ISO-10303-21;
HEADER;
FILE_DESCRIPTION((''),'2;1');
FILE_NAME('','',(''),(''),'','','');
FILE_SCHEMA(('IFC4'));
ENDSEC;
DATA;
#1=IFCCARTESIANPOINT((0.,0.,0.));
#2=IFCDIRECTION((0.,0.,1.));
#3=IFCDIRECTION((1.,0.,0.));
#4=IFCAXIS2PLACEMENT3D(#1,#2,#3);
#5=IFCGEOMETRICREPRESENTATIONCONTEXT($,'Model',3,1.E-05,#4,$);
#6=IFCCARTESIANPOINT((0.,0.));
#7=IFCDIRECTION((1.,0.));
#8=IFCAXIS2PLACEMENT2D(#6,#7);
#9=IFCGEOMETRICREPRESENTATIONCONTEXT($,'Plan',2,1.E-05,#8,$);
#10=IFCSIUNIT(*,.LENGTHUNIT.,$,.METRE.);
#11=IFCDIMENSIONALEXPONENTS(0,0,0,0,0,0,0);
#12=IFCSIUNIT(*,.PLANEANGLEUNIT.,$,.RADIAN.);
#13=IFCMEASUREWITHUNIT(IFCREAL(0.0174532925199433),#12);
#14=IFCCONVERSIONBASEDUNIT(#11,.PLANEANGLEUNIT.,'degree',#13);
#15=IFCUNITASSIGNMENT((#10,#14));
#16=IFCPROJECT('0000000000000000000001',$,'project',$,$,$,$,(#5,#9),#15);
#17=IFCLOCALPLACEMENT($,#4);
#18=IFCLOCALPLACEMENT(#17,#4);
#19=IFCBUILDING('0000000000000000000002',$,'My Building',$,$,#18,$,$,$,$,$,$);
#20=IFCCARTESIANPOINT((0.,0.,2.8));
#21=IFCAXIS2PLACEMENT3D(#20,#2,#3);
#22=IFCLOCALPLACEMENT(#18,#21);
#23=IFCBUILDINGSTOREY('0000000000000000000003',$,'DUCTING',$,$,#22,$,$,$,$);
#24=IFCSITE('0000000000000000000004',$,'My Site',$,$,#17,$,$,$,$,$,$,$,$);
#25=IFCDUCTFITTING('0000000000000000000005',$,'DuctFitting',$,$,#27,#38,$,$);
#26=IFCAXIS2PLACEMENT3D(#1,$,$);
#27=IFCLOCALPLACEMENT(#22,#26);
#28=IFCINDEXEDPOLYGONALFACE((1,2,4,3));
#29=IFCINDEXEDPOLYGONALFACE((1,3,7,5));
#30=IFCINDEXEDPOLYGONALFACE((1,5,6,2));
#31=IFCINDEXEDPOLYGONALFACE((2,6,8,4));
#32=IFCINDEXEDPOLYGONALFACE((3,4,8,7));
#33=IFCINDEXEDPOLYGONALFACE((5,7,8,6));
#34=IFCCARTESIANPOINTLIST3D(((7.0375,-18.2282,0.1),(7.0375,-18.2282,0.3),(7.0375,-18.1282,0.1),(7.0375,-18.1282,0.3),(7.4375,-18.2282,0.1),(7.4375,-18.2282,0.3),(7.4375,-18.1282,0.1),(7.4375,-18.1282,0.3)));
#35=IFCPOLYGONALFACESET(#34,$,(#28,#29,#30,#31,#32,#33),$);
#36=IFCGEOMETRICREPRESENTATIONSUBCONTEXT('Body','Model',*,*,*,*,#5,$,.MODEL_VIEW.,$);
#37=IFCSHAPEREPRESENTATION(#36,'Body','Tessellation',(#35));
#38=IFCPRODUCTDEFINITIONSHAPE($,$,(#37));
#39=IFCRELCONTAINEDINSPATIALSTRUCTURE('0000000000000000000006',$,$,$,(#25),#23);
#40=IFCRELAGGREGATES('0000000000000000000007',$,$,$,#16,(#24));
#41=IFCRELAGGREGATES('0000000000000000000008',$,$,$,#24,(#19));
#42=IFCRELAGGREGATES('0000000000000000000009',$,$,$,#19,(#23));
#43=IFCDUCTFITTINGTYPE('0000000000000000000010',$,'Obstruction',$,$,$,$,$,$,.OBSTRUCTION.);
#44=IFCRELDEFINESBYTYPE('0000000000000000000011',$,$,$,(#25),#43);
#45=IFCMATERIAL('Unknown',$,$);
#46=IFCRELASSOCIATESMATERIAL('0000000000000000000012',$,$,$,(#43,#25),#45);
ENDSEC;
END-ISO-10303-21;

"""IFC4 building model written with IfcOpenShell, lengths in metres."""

from ifc_helpers import new_model, entity, si_unit, converted_unit, frame, origin_with_axes, origin_2d_with_axis, place, context, subcontext, project, spatial, rectangle, extrude, material, material_profile, profile_set, profile_usage, type_object, element, save


model = new_model("IFC4")

# Units and contexts
model_context = context("Model", 3, precision=1e-05, world=origin_with_axes())
plan_context = context("Plan", 2, precision=1e-05, world=origin_2d_with_axis())
body_context = subcontext(model_context, "Body", "Model", "MODEL_VIEW")
ifc_project = project(units=[si_unit("LENGTHUNIT", "METRE"), converted_unit("PLANEANGLEUNIT", "degree", entity("IfcReal", 0.0174532925199433), si_unit("PLANEANGLEUNIT", "RADIAN"), dimensions=[0, 0, 0, 0, 0, 0, 0])], contexts=[model_context, plan_context])

# Site, building, storey
site_placement = place(None, origin_with_axes())
site = spatial("IfcSite", under=ifc_project, at=site_placement, Name="My Site")
building_placement = place(site_placement, origin_with_axes())
building = spatial("IfcBuilding", under=site, at=building_placement, Name="My Building")
storey_placement = place(building_placement, frame((0.0, 0.0, 2.8), z_axis=(0.0, 0.0, 1.0), x_axis=(1.0, 0.0, 0.0)))
storey = spatial("IfcBuildingStorey", under=building, at=storey_placement, Name="DUCTING")

# Shared definitions
ifc_material = material(Name="Unknown")

# Duct fitting
ifc_material_profile_1 = material_profile(ifc_material, rectangle(XDim=0.4, YDim=0.2))
ifc_profile_set_1 = profile_set([ifc_material_profile_1])
duct_fitting_type_1 = type_object("IfcDuctFittingType", Name="Obstruction", PredefinedType="OBSTRUCTION", material=ifc_profile_set_1)
ifc_profile_usage_1 = profile_usage(ifc_profile_set_1, cardinal=5)
duct_fitting_1_placement = place(storey_placement, frame((7.2375, -18.2282, 0.2), z_axis=(0.000001, 1.0, 0.0), x_axis=(-1.0, 0.000001, 0.0)))
element("IfcDuctFitting", 1, at=duct_fitting_1_placement, inside=storey, type_object=duct_fitting_type_1, material=ifc_profile_usage_1, Name="DuctFitting", context=body_context, shape_type="SweptSolid", body=[
    extrude(rectangle(XDim=0.4, YDim=0.2), origin_with_axes(), (0.0, 0.0, 1.0), 0.1),
])

save(model, "model.ifc")
